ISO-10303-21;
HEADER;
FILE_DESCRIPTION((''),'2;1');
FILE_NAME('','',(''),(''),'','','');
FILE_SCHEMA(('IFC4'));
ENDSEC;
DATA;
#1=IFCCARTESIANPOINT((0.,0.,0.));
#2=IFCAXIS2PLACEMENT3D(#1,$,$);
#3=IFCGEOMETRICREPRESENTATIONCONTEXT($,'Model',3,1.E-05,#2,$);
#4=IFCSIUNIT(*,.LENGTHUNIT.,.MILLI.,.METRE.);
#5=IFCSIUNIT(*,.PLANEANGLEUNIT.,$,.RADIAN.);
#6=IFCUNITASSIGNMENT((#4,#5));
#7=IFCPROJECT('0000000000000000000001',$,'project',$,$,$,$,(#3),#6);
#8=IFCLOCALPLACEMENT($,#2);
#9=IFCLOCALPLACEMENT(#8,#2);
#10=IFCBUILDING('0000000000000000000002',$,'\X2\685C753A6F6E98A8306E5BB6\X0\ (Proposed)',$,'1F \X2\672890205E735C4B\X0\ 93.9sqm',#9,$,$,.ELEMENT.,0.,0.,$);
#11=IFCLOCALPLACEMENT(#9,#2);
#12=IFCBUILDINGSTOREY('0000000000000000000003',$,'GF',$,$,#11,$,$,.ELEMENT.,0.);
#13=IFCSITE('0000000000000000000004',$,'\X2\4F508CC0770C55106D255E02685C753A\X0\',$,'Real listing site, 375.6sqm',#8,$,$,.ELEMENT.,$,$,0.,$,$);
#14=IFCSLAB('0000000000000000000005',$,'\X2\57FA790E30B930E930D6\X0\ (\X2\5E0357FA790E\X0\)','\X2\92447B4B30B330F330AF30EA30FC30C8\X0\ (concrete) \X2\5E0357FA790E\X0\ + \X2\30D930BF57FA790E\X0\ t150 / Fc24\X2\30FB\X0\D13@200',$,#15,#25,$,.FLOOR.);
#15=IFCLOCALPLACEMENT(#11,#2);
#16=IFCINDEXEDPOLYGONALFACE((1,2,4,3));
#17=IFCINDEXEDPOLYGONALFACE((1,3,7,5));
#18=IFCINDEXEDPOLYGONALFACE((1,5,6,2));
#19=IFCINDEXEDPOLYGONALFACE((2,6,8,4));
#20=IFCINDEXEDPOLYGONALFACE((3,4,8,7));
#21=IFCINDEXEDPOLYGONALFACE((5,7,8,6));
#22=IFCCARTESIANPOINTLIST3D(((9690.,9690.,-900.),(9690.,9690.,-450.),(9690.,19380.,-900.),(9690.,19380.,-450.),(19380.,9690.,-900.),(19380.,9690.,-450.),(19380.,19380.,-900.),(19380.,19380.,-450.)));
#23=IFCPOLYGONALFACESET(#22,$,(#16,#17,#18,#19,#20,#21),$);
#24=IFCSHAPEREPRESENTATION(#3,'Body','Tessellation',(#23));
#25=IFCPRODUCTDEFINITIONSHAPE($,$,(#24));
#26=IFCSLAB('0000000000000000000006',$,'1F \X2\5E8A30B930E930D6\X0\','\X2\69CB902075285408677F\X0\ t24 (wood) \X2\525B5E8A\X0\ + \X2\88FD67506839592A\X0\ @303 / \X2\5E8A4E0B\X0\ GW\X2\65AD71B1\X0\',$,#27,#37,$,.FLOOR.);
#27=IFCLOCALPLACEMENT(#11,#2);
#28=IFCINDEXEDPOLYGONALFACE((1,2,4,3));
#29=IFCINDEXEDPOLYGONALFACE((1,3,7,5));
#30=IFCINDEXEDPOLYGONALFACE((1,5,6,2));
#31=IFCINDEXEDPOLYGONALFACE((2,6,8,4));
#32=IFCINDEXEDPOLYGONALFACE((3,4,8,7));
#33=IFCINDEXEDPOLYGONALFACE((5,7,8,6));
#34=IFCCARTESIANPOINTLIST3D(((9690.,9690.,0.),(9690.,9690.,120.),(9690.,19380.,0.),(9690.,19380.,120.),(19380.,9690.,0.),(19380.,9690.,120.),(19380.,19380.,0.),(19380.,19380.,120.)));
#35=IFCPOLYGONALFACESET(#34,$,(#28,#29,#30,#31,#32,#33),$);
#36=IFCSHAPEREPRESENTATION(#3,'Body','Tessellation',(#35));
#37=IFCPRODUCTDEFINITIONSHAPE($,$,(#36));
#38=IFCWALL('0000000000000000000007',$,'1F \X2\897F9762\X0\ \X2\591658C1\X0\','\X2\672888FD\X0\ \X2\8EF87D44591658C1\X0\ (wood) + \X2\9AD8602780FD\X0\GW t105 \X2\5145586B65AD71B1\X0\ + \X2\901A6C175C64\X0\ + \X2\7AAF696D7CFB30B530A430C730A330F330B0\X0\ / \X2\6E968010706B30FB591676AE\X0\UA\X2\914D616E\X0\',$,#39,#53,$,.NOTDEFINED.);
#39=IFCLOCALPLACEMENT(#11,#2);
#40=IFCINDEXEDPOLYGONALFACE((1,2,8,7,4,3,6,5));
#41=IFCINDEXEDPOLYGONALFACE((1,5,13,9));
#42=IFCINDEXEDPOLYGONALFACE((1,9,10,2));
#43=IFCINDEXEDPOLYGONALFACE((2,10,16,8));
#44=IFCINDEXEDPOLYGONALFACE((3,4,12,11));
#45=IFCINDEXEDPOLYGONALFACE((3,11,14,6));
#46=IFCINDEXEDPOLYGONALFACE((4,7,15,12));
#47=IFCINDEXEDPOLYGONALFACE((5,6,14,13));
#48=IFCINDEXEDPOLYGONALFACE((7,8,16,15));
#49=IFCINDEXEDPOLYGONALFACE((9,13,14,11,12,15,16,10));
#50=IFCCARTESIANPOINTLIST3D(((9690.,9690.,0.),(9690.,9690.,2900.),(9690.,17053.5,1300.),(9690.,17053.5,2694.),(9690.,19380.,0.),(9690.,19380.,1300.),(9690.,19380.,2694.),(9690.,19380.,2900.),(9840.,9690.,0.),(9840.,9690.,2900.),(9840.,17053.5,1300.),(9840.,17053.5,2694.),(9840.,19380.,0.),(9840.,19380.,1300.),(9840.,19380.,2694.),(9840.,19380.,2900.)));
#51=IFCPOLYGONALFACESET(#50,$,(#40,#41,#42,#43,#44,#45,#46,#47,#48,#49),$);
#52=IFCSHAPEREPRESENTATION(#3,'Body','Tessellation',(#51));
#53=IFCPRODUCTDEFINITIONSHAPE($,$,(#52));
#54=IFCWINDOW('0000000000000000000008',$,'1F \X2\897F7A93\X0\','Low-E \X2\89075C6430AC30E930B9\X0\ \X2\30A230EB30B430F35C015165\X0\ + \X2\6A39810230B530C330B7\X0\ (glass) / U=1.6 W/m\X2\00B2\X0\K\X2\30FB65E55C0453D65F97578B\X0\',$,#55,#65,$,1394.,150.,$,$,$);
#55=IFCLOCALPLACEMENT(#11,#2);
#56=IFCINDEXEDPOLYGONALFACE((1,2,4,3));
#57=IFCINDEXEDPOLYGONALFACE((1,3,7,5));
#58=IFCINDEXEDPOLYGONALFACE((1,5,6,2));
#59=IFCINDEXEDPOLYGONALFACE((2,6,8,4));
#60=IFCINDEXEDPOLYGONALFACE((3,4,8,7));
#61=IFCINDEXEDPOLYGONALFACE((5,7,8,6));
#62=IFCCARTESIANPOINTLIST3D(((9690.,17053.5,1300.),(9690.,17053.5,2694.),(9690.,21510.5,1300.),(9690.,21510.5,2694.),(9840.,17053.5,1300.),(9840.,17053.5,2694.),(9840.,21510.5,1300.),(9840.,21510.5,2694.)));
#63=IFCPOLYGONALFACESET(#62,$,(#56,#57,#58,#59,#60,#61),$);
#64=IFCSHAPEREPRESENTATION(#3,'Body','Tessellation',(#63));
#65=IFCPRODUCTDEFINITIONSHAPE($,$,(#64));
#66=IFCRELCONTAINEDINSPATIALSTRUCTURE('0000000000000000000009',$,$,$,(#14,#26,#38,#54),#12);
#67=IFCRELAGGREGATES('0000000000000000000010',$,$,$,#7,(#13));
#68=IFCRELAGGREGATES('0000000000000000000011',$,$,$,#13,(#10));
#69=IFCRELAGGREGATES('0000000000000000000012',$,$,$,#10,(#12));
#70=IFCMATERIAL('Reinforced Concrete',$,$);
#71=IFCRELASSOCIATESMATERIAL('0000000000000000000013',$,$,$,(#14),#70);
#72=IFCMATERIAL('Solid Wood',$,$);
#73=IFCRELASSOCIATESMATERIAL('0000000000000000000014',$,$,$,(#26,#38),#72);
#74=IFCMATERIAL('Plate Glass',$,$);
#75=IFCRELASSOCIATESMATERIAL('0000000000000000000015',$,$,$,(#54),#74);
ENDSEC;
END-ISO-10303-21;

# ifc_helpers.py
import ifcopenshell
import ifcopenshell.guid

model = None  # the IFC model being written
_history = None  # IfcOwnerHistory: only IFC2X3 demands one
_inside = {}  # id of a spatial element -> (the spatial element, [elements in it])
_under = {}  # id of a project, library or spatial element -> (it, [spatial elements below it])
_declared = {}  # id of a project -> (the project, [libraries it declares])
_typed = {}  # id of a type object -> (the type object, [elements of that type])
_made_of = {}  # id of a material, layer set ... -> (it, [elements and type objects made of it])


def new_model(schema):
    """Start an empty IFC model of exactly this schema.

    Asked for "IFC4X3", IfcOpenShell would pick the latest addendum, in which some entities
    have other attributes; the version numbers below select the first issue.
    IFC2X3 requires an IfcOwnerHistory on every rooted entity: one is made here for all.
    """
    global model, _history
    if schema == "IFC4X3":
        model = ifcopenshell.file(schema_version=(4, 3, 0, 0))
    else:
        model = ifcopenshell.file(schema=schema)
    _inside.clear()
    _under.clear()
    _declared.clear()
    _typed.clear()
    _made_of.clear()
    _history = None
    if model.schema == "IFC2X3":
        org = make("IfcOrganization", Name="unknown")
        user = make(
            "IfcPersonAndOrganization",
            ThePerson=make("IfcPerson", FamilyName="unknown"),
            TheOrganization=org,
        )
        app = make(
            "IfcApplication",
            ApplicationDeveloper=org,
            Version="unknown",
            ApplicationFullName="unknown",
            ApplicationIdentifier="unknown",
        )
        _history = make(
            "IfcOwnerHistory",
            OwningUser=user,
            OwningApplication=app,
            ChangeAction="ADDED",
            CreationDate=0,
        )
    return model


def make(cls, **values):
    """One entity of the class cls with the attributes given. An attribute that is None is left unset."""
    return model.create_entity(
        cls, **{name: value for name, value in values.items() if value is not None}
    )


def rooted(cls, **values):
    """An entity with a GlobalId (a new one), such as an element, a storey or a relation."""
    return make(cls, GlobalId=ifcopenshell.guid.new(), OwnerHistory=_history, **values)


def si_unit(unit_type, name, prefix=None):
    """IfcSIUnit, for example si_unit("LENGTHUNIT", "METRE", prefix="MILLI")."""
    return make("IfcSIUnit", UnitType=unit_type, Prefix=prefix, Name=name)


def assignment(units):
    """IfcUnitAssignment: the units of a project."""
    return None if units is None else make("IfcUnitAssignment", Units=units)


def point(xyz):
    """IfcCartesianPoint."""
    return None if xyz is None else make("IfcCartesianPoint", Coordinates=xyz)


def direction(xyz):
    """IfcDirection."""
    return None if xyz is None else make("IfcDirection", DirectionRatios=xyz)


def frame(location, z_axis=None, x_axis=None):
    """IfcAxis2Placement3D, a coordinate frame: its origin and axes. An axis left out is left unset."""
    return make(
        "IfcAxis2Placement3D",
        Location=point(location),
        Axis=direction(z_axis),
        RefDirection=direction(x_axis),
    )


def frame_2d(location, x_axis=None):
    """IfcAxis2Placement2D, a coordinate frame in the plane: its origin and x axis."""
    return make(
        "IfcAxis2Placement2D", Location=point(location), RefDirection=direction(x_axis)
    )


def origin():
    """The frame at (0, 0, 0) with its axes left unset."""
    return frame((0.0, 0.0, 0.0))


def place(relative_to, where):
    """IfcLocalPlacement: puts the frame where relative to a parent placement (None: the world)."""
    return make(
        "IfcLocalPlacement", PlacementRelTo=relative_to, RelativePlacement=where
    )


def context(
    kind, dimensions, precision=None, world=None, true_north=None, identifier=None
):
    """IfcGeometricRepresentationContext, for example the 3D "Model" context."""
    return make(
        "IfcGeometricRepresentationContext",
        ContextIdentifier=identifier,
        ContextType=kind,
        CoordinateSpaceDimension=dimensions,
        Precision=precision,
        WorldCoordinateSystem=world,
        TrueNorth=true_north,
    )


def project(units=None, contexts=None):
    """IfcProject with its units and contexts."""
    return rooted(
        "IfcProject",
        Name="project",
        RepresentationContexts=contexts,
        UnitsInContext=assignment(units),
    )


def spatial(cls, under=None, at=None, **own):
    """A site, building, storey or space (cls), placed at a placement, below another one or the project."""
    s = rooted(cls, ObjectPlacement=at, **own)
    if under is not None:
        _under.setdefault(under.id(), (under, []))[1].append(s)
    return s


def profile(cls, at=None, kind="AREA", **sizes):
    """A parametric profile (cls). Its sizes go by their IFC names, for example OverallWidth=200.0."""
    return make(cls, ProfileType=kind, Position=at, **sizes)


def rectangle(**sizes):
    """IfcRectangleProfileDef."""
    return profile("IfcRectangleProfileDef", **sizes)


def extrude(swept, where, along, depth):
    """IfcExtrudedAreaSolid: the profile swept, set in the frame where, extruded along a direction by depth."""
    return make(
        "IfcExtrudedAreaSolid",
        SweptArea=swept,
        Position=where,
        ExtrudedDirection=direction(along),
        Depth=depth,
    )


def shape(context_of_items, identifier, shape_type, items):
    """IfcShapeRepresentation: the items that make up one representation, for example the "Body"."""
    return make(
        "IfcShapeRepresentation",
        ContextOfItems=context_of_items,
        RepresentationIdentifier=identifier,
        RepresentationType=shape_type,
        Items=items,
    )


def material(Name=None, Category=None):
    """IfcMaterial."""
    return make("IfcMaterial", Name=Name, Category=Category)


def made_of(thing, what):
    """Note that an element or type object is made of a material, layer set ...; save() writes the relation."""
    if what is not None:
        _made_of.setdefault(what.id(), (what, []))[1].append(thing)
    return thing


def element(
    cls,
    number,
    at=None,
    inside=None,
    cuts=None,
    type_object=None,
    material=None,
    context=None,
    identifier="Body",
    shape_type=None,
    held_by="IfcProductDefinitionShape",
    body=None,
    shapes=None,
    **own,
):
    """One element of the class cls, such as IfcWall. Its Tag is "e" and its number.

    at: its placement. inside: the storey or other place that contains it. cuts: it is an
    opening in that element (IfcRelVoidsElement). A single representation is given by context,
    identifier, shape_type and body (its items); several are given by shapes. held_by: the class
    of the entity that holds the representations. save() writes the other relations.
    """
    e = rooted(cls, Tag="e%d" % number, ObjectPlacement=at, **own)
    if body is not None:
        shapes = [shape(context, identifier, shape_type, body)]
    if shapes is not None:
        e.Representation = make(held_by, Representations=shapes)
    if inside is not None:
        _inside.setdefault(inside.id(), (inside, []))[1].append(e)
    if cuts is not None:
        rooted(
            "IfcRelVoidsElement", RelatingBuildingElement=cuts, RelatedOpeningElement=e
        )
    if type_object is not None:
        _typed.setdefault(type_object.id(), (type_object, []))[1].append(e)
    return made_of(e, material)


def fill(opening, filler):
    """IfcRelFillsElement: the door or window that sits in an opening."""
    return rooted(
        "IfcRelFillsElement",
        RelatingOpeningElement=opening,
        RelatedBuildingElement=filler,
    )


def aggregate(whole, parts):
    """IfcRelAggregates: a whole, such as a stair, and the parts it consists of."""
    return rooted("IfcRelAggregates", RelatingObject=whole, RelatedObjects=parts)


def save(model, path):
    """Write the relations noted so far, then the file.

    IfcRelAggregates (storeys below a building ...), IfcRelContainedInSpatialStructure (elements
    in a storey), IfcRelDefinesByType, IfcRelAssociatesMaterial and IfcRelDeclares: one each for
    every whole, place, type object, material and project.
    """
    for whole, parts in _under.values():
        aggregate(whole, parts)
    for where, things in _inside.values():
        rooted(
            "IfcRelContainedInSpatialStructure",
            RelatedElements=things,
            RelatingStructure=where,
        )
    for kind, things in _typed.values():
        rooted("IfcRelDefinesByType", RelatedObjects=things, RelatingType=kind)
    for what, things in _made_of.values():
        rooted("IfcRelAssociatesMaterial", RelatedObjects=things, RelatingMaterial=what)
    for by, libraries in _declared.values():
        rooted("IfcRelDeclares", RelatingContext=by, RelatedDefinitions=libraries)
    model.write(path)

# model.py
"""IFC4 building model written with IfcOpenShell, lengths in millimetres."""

from ifc_helpers import new_model, si_unit, frame, frame_2d, origin, place, context, project, spatial, rectangle, extrude, material, element, fill, save


model = new_model("IFC4")

# Units and contexts
model_context = context("Model", 3, precision=1e-05, world=origin())
ifc_project = project(units=[si_unit("LENGTHUNIT", "METRE", prefix="MILLI"), si_unit("PLANEANGLEUNIT", "RADIAN")], contexts=[model_context])

# Site, building, storey
site_placement = place(None, origin())
site = spatial("IfcSite", under=ifc_project, at=site_placement, Name="佐賀県唐津市桜町", ObjectType="Real listing site, 375.6sqm", CompositionType="ELEMENT", RefElevation=0.0)
building_placement = place(site_placement, origin())
building = spatial("IfcBuilding", under=site, at=building_placement, Name="桜町潮風の家 (Proposed)", ObjectType="1F 木造平屋 93.9sqm", CompositionType="ELEMENT", ElevationOfRefHeight=0.0, ElevationOfTerrain=0.0)
storey_placement = place(building_placement, origin())
storey = spatial("IfcBuildingStorey", under=building, at=storey_placement, Name="GF", CompositionType="ELEMENT", Elevation=0.0)

# Slabs
ifc_material_1 = material(Name="Reinforced Concrete")
slab_1_placement = place(storey_placement, frame((4845.0, 4845.0, -450.0)))
element("IfcSlab", 1, at=slab_1_placement, inside=storey, material=ifc_material_1, Name="基礎スラブ (布基礎)", Description="鉄筋コンクリート (concrete) 布基礎 + ベタ基礎 t150 / Fc24・D13@200", PredefinedType="FLOOR", context=model_context, shape_type="SweptSolid", body=[
    extrude(rectangle(XDim=9690.0, YDim=9690.0, at=frame_2d((4845.0, 4845.0))), frame((4845.0, 4845.0, -450.0)), (0.0, 0.0, 1.0), 450.0),
])
ifc_material_2 = material(Name="Solid Wood")
slab_2_placement = place(storey_placement, frame((4845.0, 4845.0, 0.0)))
element("IfcSlab", 2, at=slab_2_placement, inside=storey, material=ifc_material_2, Name="1F 床スラブ", Description="構造用合板 t24 (wood) 剛床 + 製材根太 @303 / 床下 GW断熱", PredefinedType="FLOOR", context=model_context, shape_type="SweptSolid", body=[
    extrude(rectangle(XDim=9690.0, YDim=9690.0, at=frame_2d((4845.0, 4845.0))), frame((4845.0, 4845.0, 0.0)), (0.0, 0.0, 1.0), 120.0),
])

# Shared definitions
ifc_material_3 = material(Name="Plate Glass")

# Wall, opening, window
wall_1_placement = place(storey_placement, frame((4845.0, 4845.0, 0.0)))
wall_1 = element("IfcWall", 3, at=wall_1_placement, inside=storey, material=ifc_material_2, Name="1F 西面 外壁", Description="木製 軸組外壁 (wood) + 高性能GW t105 充填断熱 + 通気層 + 窯業系サイディング / 準耐火・外皮UA配慮", PredefinedType="NOTDEFINED", context=model_context, shape_type="SweptSolid", body=[
    extrude(rectangle(XDim=150.0, YDim=9690.0, at=frame_2d((75.0, 4845.0))), frame((4845.0, 4845.0, 0.0)), (0.0, 0.0, 1.0), 2900.0),
])
opening_1_placement = place(storey_placement, frame((4845.0, 8527.0, 650.0)))
opening_1 = element("IfcOpeningElement", 4, at=opening_1_placement, cuts=wall_1, PredefinedType="NOTDEFINED", context=model_context, shape_type="SweptSolid", body=[
    extrude(rectangle(XDim=150.0, YDim=4457.0, at=frame_2d((75.0, 2228.0))), frame((4845.0, 8527.0, 650.0)), (0.0, 0.0, 1.0), 1394.0),
])
window_1_placement = place(storey_placement, frame((4845.0, 8527.0, 650.0)))
window_1 = element("IfcWindow", 5, at=window_1_placement, inside=storey, material=ifc_material_3, Name="1F 西窓", Description="Low-E 複層ガラス アルゴン封入 + 樹脂サッシ (glass) / U=1.6 W/m²K・日射取得型", OverallHeight=1394.0, OverallWidth=150.0, context=model_context, shape_type="SweptSolid", body=[
    extrude(rectangle(XDim=150.0, YDim=4457.0, at=frame_2d((75.0, 2228.0))), frame((4845.0, 8527.0, 650.0)), (0.0, 0.0, 1.0), 1394.0),
])
fill(opening_1, window_1)

save(model, "model.ifc")
